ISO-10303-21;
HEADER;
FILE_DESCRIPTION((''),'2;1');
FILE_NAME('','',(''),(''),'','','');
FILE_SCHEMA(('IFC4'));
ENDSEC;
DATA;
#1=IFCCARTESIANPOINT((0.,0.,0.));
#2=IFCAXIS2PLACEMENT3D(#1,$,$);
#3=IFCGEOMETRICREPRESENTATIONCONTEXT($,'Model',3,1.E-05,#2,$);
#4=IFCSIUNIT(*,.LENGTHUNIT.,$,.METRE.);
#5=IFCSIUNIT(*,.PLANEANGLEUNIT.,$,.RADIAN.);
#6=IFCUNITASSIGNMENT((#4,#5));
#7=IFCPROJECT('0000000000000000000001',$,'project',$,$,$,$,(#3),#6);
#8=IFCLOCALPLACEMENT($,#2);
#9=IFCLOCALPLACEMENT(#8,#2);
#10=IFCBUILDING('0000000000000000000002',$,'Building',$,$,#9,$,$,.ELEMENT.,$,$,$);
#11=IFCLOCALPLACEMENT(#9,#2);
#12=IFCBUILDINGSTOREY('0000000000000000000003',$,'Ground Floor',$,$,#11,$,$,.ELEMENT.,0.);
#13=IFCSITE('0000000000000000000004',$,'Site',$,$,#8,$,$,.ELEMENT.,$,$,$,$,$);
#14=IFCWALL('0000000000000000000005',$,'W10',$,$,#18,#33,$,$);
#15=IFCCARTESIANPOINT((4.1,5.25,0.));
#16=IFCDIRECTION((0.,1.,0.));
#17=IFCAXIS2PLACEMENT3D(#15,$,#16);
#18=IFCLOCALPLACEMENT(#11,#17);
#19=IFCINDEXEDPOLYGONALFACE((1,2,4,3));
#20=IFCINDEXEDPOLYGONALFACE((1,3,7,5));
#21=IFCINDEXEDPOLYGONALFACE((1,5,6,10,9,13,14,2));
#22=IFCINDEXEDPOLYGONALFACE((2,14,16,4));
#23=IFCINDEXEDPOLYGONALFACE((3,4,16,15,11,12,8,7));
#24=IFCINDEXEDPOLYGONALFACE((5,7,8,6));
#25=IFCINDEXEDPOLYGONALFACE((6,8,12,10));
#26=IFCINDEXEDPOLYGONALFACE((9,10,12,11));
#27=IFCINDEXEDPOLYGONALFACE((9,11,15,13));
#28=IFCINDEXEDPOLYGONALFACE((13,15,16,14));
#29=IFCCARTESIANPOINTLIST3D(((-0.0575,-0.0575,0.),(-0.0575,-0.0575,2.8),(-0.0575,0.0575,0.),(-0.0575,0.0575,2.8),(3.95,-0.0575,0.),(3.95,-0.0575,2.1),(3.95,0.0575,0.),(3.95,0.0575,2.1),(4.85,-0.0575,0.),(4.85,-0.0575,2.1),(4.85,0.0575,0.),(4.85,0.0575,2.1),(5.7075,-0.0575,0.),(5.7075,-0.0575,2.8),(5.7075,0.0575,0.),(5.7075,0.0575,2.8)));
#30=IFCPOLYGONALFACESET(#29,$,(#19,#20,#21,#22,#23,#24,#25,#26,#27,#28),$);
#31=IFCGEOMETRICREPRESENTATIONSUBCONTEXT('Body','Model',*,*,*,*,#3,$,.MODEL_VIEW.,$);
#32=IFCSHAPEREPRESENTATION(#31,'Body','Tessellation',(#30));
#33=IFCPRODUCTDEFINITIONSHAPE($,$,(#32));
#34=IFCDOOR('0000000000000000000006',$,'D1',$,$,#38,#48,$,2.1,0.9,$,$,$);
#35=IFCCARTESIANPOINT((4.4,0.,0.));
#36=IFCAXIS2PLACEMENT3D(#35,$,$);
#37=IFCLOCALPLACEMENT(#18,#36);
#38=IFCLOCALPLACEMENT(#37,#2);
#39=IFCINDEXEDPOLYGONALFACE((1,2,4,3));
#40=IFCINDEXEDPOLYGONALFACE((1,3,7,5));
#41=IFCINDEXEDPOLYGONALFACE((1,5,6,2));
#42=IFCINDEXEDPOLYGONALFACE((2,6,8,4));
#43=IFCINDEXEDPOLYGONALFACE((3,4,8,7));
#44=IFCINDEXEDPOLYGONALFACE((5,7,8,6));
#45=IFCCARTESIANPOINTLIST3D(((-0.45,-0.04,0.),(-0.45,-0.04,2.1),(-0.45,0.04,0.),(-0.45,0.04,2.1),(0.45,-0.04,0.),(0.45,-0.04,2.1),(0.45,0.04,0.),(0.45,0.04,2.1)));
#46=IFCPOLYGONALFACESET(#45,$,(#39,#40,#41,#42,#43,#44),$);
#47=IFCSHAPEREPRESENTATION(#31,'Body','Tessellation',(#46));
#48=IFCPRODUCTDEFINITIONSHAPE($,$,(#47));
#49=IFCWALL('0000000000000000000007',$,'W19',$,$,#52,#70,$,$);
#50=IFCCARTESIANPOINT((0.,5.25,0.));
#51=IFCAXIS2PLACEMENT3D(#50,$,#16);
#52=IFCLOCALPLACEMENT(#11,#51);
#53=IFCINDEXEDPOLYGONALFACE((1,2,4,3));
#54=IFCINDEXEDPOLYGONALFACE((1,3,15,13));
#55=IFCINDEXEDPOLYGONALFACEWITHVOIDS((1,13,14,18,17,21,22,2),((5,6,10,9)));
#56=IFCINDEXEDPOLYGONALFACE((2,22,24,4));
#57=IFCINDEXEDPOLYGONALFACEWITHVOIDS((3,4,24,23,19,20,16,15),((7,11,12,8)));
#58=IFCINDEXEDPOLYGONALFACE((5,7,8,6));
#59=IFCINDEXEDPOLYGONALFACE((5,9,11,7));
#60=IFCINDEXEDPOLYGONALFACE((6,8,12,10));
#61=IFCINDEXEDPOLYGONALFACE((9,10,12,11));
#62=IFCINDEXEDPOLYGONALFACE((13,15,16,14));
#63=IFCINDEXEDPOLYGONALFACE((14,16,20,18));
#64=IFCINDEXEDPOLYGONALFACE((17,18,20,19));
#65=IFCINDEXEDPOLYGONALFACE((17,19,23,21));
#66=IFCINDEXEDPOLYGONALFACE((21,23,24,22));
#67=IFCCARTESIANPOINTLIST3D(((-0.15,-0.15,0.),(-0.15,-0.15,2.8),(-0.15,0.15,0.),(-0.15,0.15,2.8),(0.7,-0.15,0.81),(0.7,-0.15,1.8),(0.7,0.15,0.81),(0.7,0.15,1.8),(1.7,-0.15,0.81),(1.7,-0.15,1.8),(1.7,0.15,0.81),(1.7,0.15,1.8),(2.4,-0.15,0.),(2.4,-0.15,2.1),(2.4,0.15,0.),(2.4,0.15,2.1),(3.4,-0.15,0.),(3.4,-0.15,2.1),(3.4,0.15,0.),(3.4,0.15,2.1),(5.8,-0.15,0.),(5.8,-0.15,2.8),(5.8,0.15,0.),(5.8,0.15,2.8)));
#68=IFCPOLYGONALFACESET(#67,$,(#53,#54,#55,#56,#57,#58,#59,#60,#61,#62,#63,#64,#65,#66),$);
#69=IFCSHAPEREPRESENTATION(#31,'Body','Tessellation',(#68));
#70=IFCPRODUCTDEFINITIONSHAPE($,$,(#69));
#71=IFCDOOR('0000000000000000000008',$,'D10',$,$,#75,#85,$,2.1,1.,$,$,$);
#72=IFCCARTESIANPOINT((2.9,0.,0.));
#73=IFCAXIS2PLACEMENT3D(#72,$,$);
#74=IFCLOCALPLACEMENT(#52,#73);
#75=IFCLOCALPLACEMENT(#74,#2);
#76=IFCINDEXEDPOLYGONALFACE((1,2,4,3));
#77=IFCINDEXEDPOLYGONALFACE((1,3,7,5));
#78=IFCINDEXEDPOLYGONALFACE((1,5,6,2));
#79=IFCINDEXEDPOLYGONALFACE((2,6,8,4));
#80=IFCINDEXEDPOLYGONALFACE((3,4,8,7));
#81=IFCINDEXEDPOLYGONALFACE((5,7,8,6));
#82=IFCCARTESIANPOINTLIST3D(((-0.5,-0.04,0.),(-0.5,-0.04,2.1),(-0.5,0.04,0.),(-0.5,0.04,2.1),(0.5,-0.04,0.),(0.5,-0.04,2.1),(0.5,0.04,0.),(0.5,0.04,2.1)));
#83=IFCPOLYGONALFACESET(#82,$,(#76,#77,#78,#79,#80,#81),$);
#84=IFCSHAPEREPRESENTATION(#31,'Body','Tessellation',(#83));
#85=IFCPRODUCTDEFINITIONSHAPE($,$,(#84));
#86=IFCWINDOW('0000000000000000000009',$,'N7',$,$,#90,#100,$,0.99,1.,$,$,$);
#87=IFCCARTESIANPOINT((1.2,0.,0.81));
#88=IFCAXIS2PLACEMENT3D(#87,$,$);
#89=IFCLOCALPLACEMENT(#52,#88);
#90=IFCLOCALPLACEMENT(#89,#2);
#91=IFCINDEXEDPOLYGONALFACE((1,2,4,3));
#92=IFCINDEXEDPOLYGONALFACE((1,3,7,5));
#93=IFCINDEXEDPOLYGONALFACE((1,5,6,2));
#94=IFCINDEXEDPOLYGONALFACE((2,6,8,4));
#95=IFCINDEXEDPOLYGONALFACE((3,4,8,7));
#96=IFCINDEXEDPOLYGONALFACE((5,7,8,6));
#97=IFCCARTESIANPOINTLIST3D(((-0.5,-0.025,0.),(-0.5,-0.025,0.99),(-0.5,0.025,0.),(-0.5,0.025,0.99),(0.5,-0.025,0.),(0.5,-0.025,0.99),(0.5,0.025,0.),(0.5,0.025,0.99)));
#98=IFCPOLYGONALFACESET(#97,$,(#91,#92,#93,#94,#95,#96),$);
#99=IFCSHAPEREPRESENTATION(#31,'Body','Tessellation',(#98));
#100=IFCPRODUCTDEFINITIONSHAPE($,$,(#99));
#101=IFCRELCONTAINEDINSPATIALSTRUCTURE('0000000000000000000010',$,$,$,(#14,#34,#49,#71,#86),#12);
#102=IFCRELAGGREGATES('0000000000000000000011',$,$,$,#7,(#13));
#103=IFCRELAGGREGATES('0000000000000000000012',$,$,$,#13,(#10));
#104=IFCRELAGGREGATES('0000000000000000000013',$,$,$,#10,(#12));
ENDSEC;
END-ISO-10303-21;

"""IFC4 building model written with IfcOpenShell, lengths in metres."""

from ifc_helpers import new_model, si_unit, frame, frame_2d, origin, origin_2d, place, context, subcontext, project, spatial, rectangle, extrude, element, fill, save


model = new_model("IFC4")

# Units and contexts
model_context = context("Model", 3, precision=1e-05, world=origin())
body_context = subcontext(model_context, "Body", "Model", "MODEL_VIEW")
ifc_project = project(units=[si_unit("LENGTHUNIT", "METRE"), si_unit("PLANEANGLEUNIT", "RADIAN")], contexts=[model_context])

# Site, building, storey
site_placement = place(None, origin())
site = spatial("IfcSite", under=ifc_project, at=site_placement, Name="Site", CompositionType="ELEMENT")
building_placement = place(site_placement, origin())
building = spatial("IfcBuilding", under=site, at=building_placement, Name="Building", CompositionType="ELEMENT")
storey_placement = place(building_placement, origin())
storey = spatial("IfcBuildingStorey", under=building, at=storey_placement, Name="Ground Floor", CompositionType="ELEMENT", Elevation=0.0)

# Wall, opening, door
wall_1_placement = place(storey_placement, frame((4.1, 5.25, 0.0), x_axis=(0.0, 1.0, 0.0)))
wall_1 = element("IfcWall", 1, at=wall_1_placement, inside=storey, Name="W10", context=body_context, shape_type="SweptSolid", body=[
    extrude(rectangle(XDim=5.765, YDim=0.115, at=frame_2d((2.825, 0.0))), origin(), (0.0, 0.0, 1.0), 2.8),
])
opening_1_placement = place(wall_1_placement, frame((4.4, 0.0, 0.0)))
opening_1 = element("IfcOpeningElement", 2, at=opening_1_placement, cuts=wall_1, context=body_context, shape_type="SweptSolid", body=[
    extrude(rectangle(XDim=0.9, YDim=0.215, at=origin_2d()), origin(), (0.0, 0.0, 1.0), 2.1),
])
door_1_placement = place(opening_1_placement, origin())
door_1 = element("IfcDoor", 3, at=door_1_placement, inside=storey, Name="D1", OverallHeight=2.1, OverallWidth=0.9, context=body_context, shape_type="SweptSolid", body=[
    extrude(rectangle(XDim=0.9, YDim=0.08, at=origin_2d()), origin(), (0.0, 0.0, 1.0), 2.1),
])
fill(opening_1, door_1)

# Wall, openings, door, window
wall_2_placement = place(storey_placement, frame((0.0, 5.25, 0.0), x_axis=(0.0, 1.0, 0.0)))
wall_2 = element("IfcWall", 4, at=wall_2_placement, inside=storey, Name="W19", context=body_context, shape_type="SweptSolid", body=[
    extrude(rectangle(XDim=5.95, YDim=0.3, at=frame_2d((2.825, 0.0))), origin(), (0.0, 0.0, 1.0), 2.8),
])
opening_2_placement = place(wall_2_placement, frame((2.9, 0.0, 0.0)))
opening_2 = element("IfcOpeningElement", 5, at=opening_2_placement, cuts=wall_2, context=body_context, shape_type="SweptSolid", body=[
    extrude(rectangle(XDim=1.0, YDim=0.4, at=origin_2d()), origin(), (0.0, 0.0, 1.0), 2.1),
])
opening_3_placement = place(wall_2_placement, frame((1.2, 0.0, 0.81)))
opening_3 = element("IfcOpeningElement", 6, at=opening_3_placement, cuts=wall_2, context=body_context, shape_type="SweptSolid", body=[
    extrude(rectangle(XDim=1.0, YDim=0.4, at=origin_2d()), origin(), (0.0, 0.0, 1.0), 0.99),
])
door_2_placement = place(opening_2_placement, origin())
door_2 = element("IfcDoor", 7, at=door_2_placement, inside=storey, Name="D10", OverallHeight=2.1, OverallWidth=1.0, context=body_context, shape_type="SweptSolid", body=[
    extrude(rectangle(XDim=1.0, YDim=0.08, at=origin_2d()), origin(), (0.0, 0.0, 1.0), 2.1),
])
fill(opening_2, door_2)
window_1_placement = place(opening_3_placement, origin())
window_1 = element("IfcWindow", 8, at=window_1_placement, inside=storey, Name="N7", OverallHeight=0.99, OverallWidth=1.0, context=body_context, shape_type="SweptSolid", body=[
    extrude(rectangle(XDim=1.0, YDim=0.05, at=origin_2d()), origin(), (0.0, 0.0, 1.0), 0.99),
])
fill(opening_3, window_1)

save(model, "model.ifc")
